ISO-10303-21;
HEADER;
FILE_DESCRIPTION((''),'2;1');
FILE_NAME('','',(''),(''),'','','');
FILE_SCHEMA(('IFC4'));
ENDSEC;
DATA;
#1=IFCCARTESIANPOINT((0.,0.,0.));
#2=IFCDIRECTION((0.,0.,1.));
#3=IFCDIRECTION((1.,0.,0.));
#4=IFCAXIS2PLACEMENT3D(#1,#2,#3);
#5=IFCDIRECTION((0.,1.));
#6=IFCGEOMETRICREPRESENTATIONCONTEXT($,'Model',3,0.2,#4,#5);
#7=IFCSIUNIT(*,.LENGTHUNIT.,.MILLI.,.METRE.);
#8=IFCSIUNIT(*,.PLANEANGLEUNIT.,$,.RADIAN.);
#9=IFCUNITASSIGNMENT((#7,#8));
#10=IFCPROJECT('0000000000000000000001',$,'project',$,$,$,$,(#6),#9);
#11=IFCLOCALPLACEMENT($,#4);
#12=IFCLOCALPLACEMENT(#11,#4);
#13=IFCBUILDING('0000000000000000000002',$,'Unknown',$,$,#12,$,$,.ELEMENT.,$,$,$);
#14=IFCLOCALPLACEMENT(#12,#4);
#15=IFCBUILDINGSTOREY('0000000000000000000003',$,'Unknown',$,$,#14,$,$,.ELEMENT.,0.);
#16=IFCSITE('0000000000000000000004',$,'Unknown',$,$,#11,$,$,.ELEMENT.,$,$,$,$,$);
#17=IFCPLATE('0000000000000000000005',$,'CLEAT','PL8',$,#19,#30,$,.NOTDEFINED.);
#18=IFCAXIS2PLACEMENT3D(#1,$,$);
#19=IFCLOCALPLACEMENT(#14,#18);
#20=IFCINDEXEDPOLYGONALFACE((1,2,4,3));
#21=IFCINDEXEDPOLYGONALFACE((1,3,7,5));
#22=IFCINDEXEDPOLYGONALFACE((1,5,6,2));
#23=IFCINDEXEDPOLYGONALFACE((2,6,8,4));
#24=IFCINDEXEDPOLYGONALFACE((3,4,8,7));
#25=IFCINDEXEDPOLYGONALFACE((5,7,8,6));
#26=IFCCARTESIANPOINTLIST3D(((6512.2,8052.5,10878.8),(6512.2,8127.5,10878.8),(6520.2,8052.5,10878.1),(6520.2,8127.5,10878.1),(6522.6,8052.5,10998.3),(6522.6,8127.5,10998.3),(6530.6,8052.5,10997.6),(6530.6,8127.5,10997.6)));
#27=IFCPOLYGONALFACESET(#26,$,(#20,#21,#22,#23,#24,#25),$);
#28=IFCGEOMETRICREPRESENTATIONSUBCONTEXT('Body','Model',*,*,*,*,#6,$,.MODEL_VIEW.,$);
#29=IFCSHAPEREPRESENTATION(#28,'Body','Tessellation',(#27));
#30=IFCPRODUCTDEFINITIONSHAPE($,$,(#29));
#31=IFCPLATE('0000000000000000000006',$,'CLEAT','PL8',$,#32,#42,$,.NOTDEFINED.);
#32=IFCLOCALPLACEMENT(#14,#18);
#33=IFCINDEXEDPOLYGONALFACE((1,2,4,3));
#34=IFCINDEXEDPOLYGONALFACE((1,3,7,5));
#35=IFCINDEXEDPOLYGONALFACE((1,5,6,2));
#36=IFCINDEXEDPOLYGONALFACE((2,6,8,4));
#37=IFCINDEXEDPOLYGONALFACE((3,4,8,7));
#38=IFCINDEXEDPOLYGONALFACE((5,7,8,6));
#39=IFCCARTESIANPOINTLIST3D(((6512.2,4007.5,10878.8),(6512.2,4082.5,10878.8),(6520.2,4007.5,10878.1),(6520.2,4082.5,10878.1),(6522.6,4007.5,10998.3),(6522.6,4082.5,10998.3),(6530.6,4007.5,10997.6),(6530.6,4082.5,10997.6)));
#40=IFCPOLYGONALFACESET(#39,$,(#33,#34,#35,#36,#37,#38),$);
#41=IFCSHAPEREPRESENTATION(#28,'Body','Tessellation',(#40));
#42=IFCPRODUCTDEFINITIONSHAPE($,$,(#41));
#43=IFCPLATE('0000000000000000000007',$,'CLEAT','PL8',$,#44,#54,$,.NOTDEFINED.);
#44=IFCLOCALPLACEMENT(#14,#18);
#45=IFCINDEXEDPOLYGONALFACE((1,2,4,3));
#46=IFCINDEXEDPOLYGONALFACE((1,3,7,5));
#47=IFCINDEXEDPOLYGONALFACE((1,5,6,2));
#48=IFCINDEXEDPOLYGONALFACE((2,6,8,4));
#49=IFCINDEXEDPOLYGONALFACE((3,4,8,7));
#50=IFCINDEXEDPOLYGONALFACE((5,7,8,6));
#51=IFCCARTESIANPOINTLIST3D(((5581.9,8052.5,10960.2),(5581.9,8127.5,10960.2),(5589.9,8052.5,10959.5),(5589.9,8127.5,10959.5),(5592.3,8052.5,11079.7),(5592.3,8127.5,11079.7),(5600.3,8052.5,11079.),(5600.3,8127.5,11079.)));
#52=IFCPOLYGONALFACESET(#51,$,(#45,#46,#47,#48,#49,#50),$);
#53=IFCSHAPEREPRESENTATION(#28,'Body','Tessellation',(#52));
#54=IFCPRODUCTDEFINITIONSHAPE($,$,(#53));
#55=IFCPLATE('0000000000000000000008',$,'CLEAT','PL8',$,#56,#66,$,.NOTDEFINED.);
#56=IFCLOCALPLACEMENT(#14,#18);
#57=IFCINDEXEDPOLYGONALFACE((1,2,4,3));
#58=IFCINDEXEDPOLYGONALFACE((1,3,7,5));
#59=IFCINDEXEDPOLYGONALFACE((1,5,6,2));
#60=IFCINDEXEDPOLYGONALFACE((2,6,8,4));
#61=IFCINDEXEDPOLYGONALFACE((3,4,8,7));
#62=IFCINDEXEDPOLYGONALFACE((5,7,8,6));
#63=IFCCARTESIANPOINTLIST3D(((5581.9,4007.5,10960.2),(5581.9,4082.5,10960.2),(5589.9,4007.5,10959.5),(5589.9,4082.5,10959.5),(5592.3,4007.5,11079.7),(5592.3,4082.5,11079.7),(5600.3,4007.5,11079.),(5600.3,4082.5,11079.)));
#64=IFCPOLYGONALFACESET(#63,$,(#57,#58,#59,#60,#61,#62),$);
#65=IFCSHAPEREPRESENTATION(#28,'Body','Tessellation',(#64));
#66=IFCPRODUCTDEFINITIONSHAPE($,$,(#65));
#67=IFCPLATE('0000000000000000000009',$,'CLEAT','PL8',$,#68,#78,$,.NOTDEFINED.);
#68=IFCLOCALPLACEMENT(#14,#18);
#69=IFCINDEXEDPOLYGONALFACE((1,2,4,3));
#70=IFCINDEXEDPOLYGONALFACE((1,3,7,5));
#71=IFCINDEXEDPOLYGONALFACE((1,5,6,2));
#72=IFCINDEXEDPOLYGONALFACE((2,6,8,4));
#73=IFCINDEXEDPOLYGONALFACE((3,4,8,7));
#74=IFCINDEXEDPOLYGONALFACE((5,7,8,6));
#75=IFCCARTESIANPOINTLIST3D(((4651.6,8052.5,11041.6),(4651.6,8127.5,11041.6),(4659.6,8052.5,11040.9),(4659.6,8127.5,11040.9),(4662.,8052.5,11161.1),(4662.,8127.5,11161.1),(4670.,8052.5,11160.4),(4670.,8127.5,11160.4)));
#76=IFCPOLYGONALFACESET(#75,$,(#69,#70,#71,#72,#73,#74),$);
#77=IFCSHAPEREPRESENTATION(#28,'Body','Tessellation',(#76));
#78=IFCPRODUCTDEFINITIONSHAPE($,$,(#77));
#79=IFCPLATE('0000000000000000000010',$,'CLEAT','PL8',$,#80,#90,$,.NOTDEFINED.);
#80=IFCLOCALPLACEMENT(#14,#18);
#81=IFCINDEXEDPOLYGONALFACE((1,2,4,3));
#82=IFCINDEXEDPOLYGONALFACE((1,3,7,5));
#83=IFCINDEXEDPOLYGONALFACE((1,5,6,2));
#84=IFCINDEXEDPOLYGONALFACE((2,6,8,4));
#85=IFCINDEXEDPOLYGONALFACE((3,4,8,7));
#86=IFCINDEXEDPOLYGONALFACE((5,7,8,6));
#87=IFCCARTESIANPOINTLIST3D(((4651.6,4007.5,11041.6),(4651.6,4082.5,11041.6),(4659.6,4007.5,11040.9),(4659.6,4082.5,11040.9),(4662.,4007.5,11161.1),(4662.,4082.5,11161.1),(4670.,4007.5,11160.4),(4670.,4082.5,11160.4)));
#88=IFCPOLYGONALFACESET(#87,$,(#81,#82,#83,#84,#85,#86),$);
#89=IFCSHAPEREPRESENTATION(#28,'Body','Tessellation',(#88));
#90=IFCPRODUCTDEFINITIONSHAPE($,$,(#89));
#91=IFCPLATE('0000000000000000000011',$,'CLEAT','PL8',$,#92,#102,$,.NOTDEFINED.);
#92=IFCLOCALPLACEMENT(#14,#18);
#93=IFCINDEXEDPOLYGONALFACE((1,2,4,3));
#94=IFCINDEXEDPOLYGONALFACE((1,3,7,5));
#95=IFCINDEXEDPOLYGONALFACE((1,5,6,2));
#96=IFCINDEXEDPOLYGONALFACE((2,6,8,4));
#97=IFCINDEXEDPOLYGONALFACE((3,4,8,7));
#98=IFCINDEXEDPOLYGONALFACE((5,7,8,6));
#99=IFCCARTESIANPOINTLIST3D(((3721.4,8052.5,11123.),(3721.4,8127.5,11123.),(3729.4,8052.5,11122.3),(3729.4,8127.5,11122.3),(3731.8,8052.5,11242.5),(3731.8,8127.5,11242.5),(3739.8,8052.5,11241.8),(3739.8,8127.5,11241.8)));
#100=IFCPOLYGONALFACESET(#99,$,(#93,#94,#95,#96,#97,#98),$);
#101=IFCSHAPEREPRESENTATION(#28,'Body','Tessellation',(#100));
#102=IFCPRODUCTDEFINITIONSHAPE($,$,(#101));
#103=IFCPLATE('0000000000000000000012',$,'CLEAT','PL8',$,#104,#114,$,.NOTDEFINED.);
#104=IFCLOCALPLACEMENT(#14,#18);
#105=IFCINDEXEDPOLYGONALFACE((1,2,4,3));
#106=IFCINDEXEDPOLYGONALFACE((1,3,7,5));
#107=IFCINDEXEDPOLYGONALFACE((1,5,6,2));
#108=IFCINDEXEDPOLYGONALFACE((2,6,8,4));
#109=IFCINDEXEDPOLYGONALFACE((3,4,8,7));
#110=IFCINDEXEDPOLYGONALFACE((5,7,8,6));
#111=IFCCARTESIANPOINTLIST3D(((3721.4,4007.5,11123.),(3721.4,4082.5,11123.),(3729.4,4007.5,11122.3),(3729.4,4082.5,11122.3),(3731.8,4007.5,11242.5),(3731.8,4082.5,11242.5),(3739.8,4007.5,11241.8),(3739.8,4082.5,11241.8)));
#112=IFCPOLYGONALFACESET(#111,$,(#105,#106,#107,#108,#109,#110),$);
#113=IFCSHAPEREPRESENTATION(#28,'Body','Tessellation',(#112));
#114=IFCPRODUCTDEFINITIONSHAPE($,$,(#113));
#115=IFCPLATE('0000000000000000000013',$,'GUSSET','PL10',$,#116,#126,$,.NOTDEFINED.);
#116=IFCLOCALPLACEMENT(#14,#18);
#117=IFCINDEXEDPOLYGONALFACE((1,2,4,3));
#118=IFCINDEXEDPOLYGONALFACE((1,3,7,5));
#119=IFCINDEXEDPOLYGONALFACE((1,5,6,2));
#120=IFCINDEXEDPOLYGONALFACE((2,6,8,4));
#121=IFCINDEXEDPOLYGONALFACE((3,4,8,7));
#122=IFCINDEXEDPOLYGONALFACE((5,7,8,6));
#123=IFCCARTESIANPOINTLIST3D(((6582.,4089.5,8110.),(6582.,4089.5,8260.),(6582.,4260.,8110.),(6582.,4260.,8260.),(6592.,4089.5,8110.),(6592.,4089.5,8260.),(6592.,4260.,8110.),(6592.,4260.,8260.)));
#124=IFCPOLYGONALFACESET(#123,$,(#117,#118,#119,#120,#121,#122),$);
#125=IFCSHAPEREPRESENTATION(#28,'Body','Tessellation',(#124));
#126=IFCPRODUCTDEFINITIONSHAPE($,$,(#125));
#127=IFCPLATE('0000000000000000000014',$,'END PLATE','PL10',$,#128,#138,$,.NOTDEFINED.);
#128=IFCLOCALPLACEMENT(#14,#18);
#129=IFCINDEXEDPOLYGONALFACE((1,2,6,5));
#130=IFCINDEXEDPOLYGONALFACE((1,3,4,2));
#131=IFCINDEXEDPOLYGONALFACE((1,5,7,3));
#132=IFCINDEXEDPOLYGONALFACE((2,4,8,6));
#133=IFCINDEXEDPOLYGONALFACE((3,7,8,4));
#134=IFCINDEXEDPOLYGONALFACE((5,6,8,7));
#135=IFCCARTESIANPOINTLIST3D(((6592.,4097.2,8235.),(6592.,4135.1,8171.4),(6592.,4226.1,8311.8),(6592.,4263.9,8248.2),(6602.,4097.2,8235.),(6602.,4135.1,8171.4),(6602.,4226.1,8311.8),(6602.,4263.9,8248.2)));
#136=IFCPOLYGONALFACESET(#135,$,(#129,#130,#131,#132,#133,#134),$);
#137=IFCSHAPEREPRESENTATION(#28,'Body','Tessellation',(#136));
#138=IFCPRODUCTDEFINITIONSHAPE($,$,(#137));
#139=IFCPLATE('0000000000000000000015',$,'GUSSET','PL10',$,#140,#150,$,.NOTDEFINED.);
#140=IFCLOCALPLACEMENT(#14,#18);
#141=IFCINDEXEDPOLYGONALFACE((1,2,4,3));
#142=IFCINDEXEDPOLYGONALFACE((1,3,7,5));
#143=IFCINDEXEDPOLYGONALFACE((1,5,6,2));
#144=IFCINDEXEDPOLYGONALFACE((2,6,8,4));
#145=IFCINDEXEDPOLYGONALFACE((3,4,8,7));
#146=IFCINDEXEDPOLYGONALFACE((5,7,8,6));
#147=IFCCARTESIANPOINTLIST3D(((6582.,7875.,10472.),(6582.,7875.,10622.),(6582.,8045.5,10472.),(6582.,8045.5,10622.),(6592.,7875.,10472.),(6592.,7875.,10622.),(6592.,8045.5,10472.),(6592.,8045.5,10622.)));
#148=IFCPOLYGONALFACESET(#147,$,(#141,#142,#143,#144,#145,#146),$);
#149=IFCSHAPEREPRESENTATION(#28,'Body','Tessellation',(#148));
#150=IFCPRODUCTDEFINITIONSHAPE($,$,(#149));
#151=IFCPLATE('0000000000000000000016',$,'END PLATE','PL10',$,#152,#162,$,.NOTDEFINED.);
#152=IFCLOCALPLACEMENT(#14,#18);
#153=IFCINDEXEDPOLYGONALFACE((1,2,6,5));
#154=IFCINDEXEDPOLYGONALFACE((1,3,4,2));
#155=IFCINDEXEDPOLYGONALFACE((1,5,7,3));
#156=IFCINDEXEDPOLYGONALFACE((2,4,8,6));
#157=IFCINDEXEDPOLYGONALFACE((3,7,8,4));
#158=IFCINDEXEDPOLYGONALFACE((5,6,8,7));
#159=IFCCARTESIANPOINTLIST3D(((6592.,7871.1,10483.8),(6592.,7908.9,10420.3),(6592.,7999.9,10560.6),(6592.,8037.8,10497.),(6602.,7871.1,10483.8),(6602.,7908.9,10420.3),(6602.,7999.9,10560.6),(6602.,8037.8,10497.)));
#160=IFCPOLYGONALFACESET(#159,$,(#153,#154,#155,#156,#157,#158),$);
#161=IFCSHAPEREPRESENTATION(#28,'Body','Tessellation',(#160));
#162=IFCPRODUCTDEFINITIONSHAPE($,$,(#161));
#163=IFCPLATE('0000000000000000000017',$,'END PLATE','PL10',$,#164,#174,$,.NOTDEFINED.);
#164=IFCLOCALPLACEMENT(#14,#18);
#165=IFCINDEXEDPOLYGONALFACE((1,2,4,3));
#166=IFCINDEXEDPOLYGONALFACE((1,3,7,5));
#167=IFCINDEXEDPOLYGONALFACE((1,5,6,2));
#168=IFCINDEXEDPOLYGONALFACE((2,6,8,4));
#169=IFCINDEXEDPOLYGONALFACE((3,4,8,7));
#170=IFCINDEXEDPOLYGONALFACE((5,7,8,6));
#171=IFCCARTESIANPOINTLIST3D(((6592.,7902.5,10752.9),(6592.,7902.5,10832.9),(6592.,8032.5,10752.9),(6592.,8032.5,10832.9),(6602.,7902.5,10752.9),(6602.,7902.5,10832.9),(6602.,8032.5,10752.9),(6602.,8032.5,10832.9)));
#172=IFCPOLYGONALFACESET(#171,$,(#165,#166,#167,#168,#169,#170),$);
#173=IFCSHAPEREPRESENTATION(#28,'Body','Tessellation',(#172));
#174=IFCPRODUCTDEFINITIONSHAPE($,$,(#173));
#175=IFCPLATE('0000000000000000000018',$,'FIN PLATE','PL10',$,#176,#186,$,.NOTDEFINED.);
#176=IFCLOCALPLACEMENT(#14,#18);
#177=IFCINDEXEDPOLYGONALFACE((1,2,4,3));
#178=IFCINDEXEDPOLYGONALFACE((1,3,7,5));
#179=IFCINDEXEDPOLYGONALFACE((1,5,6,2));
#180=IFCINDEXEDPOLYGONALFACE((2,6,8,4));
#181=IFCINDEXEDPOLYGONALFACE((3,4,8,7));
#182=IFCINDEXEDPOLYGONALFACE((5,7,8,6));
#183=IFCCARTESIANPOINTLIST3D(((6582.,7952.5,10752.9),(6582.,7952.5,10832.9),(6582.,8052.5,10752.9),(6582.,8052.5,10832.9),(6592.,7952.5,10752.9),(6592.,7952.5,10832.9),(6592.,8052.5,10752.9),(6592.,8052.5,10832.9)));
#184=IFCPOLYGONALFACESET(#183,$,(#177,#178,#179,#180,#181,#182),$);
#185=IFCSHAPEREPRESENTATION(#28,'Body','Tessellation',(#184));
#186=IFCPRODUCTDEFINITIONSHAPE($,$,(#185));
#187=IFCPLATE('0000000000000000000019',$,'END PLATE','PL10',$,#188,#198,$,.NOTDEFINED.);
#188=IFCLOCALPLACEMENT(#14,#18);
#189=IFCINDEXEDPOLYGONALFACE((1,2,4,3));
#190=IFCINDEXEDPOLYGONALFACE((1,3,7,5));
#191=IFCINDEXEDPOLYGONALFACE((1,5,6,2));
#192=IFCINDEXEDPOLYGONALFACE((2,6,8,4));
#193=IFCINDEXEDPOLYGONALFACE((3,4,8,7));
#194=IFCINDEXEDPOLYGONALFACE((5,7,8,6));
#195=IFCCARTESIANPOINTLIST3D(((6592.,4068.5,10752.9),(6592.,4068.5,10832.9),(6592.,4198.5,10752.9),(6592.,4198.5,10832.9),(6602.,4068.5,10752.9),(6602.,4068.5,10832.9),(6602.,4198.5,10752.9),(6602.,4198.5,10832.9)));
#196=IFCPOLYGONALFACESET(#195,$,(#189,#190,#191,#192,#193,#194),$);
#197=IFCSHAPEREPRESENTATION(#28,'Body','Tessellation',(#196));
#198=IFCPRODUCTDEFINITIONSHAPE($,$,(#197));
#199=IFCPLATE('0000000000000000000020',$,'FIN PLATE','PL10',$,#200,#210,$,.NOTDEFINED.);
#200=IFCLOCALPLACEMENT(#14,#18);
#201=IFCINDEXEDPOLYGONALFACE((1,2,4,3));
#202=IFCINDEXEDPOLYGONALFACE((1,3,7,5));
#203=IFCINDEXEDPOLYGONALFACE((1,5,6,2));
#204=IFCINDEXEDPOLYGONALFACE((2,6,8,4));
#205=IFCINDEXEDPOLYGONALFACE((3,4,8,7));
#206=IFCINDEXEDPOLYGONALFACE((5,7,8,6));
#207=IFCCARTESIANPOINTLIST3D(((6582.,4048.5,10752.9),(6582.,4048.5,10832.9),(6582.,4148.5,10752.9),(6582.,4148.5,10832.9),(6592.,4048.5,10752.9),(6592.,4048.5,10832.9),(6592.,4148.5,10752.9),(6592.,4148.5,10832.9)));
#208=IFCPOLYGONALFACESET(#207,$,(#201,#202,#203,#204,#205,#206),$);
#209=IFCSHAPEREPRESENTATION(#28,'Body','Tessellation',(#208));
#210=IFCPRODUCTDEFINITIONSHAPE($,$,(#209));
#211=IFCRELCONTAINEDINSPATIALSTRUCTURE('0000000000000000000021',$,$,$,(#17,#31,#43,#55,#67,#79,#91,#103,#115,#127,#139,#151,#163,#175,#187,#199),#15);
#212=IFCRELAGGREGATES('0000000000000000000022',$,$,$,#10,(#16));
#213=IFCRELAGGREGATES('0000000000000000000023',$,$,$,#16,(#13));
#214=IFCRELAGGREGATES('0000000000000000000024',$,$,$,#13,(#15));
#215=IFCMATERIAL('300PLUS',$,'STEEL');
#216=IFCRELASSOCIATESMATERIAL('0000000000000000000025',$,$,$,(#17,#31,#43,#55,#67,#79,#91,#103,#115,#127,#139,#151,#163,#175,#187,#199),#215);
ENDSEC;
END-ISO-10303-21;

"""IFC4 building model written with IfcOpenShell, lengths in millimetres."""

from ifc_helpers import new_model, si_unit, direction, frame, origin_with_axes, place, context, subcontext, project, spatial, line, indexed_curve, outline, extrude, material, element, save


model = new_model("IFC4")

# Units and contexts
model_context = context("Model", 3, precision=0.2, world=origin_with_axes(), true_north=direction((0.0, 1.0)))
body_context = subcontext(model_context, "Body", "Model", "MODEL_VIEW")
ifc_project = project(units=[si_unit("LENGTHUNIT", "METRE", prefix="MILLI"), si_unit("PLANEANGLEUNIT", "RADIAN")], contexts=[model_context])

# Site, building, storey
site_placement = place(None, origin_with_axes())
site = spatial("IfcSite", under=ifc_project, at=site_placement, Name="Unknown", CompositionType="ELEMENT")
building_placement = place(site_placement, origin_with_axes())
building = spatial("IfcBuilding", under=site, at=building_placement, Name="Unknown", CompositionType="ELEMENT")
storey_placement = place(building_placement, origin_with_axes())
storey = spatial("IfcBuildingStorey", under=building, at=storey_placement, Name="Unknown", CompositionType="ELEMENT", Elevation=0.0)

# Plates
ifc_material_1 = material(Name="300PLUS", Category="STEEL")
for number, where, z_axis, x_axis, name in (
    (1, (6516.2, 8127.5, 10878.4), (-0.996234, 0.0, 0.086702), (0.0, -1.0, 0.0), "CLEAT"),
    (2, (6516.2, 4082.5, 10878.4), (-0.996234, 0.0, 0.086702), (0.0, -1.0, 0.0), "CLEAT"),
    (3, (5585.9, 8127.5, 10959.8), (-0.996234, 0.0, 0.086702), (0.0, -1.0, 0.0), "CLEAT"),
    (4, (5585.9, 4082.5, 10959.8), (-0.996234, 0.0, 0.086702), (0.0, -1.0, 0.0), "CLEAT"),
    (5, (4655.6, 8127.5, 11041.2), (-0.996234, 0.0, 0.086702), (0.0, -1.0, 0.0), "CLEAT"),
    (6, (4655.6, 4082.5, 11041.2), (-0.996234, 0.0, 0.086702), (0.0, -1.0, 0.0), "CLEAT"),
    (7, (3725.4, 8127.5, 11122.6), (-0.996234, 0.0, 0.086702), (0.0, -1.0, 0.0), "CLEAT"),
    (8, (3725.4, 4082.5, 11122.6), (-0.996234, 0.0, 0.086702), (0.0, -1.0, 0.0), "CLEAT"),
):
    element("IfcPlate", number, at=place(storey_placement, frame(where, z_axis=z_axis, x_axis=x_axis)), inside=storey, material=ifc_material_1, Name=name, Description="PL8", PredefinedType="NOTDEFINED", context=body_context, shape_type="SolidModel", body=[
        extrude(outline(indexed_curve([(0.0, 0.0), (75.0, 0.0), (75.0, 120.0), (0.0, 120.0)], segments=[line(1, 2, 3, 4, 1)])), frame((0.0, 0.0, 4.0), z_axis=(0.0, 0.0, 1.0), x_axis=(1.0, 0.0, 0.0)), (0.0, 0.0, -1.0), 8.0),
    ])
plate_1_placement = place(storey_placement, frame((6587.0, 4089.5, 8260.0), z_axis=(-1.0, 0.0, 0.0), x_axis=(0.0, 1.0, 0.0)))
element("IfcPlate", 9, at=plate_1_placement, inside=storey, material=ifc_material_1, Name="GUSSET", Description="PL10", PredefinedType="NOTDEFINED", context=body_context, shape_type="SolidModel", body=[
    extrude(outline(indexed_curve([(0.0, 0.0), (170.5, 0.0), (170.5, 150.0), (0.0, 150.0)], segments=[line(1, 2, 3, 4, 1)])), frame((0.0, 0.0, 5.0), z_axis=(0.0, 0.0, 1.0), x_axis=(1.0, 0.0, 0.0)), (0.0, 0.0, -1.0), 10.0),
])
plate_2_placement = place(storey_placement, frame((6597.0, 4097.2, 8235.0), z_axis=(1.0, 0.0, 0.0), x_axis=(0.0, 0.511911, -0.859038)))
element("IfcPlate", 10, at=plate_2_placement, inside=storey, material=ifc_material_1, Name="END PLATE", Description="PL10", PredefinedType="NOTDEFINED", context=body_context, shape_type="SolidModel", body=[
    extrude(outline(indexed_curve([(0.0, 0.0), (74.0, 0.0), (74.0, 150.0), (0.0, 150.0)], segments=[line(1, 2, 3, 4, 1)])), frame((0.0, 0.0, 5.0), z_axis=(0.0, 0.0, 1.0), x_axis=(1.0, 0.0, 0.0)), (0.0, 0.0, -1.0), 10.0),
])
plate_3_placement = place(storey_placement, frame((6587.0, 8045.5, 10472.0), z_axis=(-1.0, 0.0, 0.0), x_axis=(0.0, -1.0, 0.0)))
element("IfcPlate", 11, at=plate_3_placement, inside=storey, material=ifc_material_1, Name="GUSSET", Description="PL10", PredefinedType="NOTDEFINED", context=body_context, shape_type="SolidModel", body=[
    extrude(outline(indexed_curve([(0.0, 0.0), (170.5, 0.0), (170.5, 150.0), (0.0, 150.0)], segments=[line(1, 2, 3, 4, 1)])), frame((0.0, 0.0, 5.0), z_axis=(0.0, 0.0, 1.0), x_axis=(1.0, 0.0, 0.0)), (0.0, 0.0, -1.0), 10.0),
])
plate_4_placement = place(storey_placement, frame((6597.0, 7871.1, 10483.8), z_axis=(1.0, 0.0, 0.0), x_axis=(0.0, 0.511508, -0.859279)))
element("IfcPlate", 12, at=plate_4_placement, inside=storey, material=ifc_material_1, Name="END PLATE", Description="PL10", PredefinedType="NOTDEFINED", context=body_context, shape_type="SolidModel", body=[
    extrude(outline(indexed_curve([(0.0, 0.0), (73.9, 0.0), (73.9, 150.0), (-0.1, 150.0)], segments=[line(1, 2, 3, 4, 1)])), frame((0.0, 0.0, 5.0), z_axis=(0.0, 0.0, 1.0), x_axis=(1.0, 0.0, 0.0)), (0.0, 0.0, -1.0), 10.0),
])
plate_5_placement = place(storey_placement, frame((6597.0, 7902.5, 10752.9), z_axis=(1.0, 0.0, 0.0), x_axis=(0.0, 1.0, 0.0)))
element("IfcPlate", 13, at=plate_5_placement, inside=storey, material=ifc_material_1, Name="END PLATE", Description="PL10", PredefinedType="NOTDEFINED", context=body_context, shape_type="SolidModel", body=[
    extrude(outline(indexed_curve([(0.0, 0.0), (130.0, 0.0), (130.0, 80.0), (0.0, 80.0)], segments=[line(1, 2, 3, 4, 1)])), frame((0.0, 0.0, 5.0), z_axis=(0.0, 0.0, 1.0), x_axis=(1.0, 0.0, 0.0)), (0.0, 0.0, -1.0), 10.0),
])
plate_6_placement = place(storey_placement, frame((6587.0, 8052.5, 10752.9), z_axis=(-1.0, 0.0, 0.0), x_axis=(0.0, -1.0, 0.0)))
element("IfcPlate", 14, at=plate_6_placement, inside=storey, material=ifc_material_1, Name="FIN PLATE", Description="PL10", PredefinedType="NOTDEFINED", context=body_context, shape_type="SolidModel", body=[
    extrude(outline(indexed_curve([(0.0, 0.0), (100.0, 0.0), (100.0, 80.0), (0.0, 80.0)], segments=[line(1, 2, 3, 4, 1)])), frame((0.0, 0.0, 5.0), z_axis=(0.0, 0.0, 1.0), x_axis=(1.0, 0.0, 0.0)), (0.0, 0.0, -1.0), 10.0),
])
plate_7_placement = place(storey_placement, frame((6597.0, 4198.5, 10832.9), z_axis=(1.0, 0.0, 0.0), x_axis=(0.0, -1.0, 0.0)))
element("IfcPlate", 15, at=plate_7_placement, inside=storey, material=ifc_material_1, Name="END PLATE", Description="PL10", PredefinedType="NOTDEFINED", context=body_context, shape_type="SolidModel", body=[
    extrude(outline(indexed_curve([(0.0, 0.0), (130.0, 0.0), (130.0, 80.0), (0.0, 80.0)], segments=[line(1, 2, 3, 4, 1)])), frame((0.0, 0.0, 5.0), z_axis=(0.0, 0.0, 1.0), x_axis=(1.0, 0.0, 0.0)), (0.0, 0.0, -1.0), 10.0),
])
plate_8_placement = place(storey_placement, frame((6587.0, 4048.5, 10832.9), z_axis=(-1.0, 0.0, 0.0), x_axis=(0.0, 1.0, 0.0)))
element("IfcPlate", 16, at=plate_8_placement, inside=storey, material=ifc_material_1, Name="FIN PLATE", Description="PL10", PredefinedType="NOTDEFINED", context=body_context, shape_type="SolidModel", body=[
    extrude(outline(indexed_curve([(0.0, 0.0), (100.0, 0.0), (100.0, 80.0), (0.0, 80.0)], segments=[line(1, 2, 3, 4, 1)])), frame((0.0, 0.0, 5.0), z_axis=(0.0, 0.0, 1.0), x_axis=(1.0, 0.0, 0.0)), (0.0, 0.0, -1.0), 10.0),
])

save(model, "model.ifc")
